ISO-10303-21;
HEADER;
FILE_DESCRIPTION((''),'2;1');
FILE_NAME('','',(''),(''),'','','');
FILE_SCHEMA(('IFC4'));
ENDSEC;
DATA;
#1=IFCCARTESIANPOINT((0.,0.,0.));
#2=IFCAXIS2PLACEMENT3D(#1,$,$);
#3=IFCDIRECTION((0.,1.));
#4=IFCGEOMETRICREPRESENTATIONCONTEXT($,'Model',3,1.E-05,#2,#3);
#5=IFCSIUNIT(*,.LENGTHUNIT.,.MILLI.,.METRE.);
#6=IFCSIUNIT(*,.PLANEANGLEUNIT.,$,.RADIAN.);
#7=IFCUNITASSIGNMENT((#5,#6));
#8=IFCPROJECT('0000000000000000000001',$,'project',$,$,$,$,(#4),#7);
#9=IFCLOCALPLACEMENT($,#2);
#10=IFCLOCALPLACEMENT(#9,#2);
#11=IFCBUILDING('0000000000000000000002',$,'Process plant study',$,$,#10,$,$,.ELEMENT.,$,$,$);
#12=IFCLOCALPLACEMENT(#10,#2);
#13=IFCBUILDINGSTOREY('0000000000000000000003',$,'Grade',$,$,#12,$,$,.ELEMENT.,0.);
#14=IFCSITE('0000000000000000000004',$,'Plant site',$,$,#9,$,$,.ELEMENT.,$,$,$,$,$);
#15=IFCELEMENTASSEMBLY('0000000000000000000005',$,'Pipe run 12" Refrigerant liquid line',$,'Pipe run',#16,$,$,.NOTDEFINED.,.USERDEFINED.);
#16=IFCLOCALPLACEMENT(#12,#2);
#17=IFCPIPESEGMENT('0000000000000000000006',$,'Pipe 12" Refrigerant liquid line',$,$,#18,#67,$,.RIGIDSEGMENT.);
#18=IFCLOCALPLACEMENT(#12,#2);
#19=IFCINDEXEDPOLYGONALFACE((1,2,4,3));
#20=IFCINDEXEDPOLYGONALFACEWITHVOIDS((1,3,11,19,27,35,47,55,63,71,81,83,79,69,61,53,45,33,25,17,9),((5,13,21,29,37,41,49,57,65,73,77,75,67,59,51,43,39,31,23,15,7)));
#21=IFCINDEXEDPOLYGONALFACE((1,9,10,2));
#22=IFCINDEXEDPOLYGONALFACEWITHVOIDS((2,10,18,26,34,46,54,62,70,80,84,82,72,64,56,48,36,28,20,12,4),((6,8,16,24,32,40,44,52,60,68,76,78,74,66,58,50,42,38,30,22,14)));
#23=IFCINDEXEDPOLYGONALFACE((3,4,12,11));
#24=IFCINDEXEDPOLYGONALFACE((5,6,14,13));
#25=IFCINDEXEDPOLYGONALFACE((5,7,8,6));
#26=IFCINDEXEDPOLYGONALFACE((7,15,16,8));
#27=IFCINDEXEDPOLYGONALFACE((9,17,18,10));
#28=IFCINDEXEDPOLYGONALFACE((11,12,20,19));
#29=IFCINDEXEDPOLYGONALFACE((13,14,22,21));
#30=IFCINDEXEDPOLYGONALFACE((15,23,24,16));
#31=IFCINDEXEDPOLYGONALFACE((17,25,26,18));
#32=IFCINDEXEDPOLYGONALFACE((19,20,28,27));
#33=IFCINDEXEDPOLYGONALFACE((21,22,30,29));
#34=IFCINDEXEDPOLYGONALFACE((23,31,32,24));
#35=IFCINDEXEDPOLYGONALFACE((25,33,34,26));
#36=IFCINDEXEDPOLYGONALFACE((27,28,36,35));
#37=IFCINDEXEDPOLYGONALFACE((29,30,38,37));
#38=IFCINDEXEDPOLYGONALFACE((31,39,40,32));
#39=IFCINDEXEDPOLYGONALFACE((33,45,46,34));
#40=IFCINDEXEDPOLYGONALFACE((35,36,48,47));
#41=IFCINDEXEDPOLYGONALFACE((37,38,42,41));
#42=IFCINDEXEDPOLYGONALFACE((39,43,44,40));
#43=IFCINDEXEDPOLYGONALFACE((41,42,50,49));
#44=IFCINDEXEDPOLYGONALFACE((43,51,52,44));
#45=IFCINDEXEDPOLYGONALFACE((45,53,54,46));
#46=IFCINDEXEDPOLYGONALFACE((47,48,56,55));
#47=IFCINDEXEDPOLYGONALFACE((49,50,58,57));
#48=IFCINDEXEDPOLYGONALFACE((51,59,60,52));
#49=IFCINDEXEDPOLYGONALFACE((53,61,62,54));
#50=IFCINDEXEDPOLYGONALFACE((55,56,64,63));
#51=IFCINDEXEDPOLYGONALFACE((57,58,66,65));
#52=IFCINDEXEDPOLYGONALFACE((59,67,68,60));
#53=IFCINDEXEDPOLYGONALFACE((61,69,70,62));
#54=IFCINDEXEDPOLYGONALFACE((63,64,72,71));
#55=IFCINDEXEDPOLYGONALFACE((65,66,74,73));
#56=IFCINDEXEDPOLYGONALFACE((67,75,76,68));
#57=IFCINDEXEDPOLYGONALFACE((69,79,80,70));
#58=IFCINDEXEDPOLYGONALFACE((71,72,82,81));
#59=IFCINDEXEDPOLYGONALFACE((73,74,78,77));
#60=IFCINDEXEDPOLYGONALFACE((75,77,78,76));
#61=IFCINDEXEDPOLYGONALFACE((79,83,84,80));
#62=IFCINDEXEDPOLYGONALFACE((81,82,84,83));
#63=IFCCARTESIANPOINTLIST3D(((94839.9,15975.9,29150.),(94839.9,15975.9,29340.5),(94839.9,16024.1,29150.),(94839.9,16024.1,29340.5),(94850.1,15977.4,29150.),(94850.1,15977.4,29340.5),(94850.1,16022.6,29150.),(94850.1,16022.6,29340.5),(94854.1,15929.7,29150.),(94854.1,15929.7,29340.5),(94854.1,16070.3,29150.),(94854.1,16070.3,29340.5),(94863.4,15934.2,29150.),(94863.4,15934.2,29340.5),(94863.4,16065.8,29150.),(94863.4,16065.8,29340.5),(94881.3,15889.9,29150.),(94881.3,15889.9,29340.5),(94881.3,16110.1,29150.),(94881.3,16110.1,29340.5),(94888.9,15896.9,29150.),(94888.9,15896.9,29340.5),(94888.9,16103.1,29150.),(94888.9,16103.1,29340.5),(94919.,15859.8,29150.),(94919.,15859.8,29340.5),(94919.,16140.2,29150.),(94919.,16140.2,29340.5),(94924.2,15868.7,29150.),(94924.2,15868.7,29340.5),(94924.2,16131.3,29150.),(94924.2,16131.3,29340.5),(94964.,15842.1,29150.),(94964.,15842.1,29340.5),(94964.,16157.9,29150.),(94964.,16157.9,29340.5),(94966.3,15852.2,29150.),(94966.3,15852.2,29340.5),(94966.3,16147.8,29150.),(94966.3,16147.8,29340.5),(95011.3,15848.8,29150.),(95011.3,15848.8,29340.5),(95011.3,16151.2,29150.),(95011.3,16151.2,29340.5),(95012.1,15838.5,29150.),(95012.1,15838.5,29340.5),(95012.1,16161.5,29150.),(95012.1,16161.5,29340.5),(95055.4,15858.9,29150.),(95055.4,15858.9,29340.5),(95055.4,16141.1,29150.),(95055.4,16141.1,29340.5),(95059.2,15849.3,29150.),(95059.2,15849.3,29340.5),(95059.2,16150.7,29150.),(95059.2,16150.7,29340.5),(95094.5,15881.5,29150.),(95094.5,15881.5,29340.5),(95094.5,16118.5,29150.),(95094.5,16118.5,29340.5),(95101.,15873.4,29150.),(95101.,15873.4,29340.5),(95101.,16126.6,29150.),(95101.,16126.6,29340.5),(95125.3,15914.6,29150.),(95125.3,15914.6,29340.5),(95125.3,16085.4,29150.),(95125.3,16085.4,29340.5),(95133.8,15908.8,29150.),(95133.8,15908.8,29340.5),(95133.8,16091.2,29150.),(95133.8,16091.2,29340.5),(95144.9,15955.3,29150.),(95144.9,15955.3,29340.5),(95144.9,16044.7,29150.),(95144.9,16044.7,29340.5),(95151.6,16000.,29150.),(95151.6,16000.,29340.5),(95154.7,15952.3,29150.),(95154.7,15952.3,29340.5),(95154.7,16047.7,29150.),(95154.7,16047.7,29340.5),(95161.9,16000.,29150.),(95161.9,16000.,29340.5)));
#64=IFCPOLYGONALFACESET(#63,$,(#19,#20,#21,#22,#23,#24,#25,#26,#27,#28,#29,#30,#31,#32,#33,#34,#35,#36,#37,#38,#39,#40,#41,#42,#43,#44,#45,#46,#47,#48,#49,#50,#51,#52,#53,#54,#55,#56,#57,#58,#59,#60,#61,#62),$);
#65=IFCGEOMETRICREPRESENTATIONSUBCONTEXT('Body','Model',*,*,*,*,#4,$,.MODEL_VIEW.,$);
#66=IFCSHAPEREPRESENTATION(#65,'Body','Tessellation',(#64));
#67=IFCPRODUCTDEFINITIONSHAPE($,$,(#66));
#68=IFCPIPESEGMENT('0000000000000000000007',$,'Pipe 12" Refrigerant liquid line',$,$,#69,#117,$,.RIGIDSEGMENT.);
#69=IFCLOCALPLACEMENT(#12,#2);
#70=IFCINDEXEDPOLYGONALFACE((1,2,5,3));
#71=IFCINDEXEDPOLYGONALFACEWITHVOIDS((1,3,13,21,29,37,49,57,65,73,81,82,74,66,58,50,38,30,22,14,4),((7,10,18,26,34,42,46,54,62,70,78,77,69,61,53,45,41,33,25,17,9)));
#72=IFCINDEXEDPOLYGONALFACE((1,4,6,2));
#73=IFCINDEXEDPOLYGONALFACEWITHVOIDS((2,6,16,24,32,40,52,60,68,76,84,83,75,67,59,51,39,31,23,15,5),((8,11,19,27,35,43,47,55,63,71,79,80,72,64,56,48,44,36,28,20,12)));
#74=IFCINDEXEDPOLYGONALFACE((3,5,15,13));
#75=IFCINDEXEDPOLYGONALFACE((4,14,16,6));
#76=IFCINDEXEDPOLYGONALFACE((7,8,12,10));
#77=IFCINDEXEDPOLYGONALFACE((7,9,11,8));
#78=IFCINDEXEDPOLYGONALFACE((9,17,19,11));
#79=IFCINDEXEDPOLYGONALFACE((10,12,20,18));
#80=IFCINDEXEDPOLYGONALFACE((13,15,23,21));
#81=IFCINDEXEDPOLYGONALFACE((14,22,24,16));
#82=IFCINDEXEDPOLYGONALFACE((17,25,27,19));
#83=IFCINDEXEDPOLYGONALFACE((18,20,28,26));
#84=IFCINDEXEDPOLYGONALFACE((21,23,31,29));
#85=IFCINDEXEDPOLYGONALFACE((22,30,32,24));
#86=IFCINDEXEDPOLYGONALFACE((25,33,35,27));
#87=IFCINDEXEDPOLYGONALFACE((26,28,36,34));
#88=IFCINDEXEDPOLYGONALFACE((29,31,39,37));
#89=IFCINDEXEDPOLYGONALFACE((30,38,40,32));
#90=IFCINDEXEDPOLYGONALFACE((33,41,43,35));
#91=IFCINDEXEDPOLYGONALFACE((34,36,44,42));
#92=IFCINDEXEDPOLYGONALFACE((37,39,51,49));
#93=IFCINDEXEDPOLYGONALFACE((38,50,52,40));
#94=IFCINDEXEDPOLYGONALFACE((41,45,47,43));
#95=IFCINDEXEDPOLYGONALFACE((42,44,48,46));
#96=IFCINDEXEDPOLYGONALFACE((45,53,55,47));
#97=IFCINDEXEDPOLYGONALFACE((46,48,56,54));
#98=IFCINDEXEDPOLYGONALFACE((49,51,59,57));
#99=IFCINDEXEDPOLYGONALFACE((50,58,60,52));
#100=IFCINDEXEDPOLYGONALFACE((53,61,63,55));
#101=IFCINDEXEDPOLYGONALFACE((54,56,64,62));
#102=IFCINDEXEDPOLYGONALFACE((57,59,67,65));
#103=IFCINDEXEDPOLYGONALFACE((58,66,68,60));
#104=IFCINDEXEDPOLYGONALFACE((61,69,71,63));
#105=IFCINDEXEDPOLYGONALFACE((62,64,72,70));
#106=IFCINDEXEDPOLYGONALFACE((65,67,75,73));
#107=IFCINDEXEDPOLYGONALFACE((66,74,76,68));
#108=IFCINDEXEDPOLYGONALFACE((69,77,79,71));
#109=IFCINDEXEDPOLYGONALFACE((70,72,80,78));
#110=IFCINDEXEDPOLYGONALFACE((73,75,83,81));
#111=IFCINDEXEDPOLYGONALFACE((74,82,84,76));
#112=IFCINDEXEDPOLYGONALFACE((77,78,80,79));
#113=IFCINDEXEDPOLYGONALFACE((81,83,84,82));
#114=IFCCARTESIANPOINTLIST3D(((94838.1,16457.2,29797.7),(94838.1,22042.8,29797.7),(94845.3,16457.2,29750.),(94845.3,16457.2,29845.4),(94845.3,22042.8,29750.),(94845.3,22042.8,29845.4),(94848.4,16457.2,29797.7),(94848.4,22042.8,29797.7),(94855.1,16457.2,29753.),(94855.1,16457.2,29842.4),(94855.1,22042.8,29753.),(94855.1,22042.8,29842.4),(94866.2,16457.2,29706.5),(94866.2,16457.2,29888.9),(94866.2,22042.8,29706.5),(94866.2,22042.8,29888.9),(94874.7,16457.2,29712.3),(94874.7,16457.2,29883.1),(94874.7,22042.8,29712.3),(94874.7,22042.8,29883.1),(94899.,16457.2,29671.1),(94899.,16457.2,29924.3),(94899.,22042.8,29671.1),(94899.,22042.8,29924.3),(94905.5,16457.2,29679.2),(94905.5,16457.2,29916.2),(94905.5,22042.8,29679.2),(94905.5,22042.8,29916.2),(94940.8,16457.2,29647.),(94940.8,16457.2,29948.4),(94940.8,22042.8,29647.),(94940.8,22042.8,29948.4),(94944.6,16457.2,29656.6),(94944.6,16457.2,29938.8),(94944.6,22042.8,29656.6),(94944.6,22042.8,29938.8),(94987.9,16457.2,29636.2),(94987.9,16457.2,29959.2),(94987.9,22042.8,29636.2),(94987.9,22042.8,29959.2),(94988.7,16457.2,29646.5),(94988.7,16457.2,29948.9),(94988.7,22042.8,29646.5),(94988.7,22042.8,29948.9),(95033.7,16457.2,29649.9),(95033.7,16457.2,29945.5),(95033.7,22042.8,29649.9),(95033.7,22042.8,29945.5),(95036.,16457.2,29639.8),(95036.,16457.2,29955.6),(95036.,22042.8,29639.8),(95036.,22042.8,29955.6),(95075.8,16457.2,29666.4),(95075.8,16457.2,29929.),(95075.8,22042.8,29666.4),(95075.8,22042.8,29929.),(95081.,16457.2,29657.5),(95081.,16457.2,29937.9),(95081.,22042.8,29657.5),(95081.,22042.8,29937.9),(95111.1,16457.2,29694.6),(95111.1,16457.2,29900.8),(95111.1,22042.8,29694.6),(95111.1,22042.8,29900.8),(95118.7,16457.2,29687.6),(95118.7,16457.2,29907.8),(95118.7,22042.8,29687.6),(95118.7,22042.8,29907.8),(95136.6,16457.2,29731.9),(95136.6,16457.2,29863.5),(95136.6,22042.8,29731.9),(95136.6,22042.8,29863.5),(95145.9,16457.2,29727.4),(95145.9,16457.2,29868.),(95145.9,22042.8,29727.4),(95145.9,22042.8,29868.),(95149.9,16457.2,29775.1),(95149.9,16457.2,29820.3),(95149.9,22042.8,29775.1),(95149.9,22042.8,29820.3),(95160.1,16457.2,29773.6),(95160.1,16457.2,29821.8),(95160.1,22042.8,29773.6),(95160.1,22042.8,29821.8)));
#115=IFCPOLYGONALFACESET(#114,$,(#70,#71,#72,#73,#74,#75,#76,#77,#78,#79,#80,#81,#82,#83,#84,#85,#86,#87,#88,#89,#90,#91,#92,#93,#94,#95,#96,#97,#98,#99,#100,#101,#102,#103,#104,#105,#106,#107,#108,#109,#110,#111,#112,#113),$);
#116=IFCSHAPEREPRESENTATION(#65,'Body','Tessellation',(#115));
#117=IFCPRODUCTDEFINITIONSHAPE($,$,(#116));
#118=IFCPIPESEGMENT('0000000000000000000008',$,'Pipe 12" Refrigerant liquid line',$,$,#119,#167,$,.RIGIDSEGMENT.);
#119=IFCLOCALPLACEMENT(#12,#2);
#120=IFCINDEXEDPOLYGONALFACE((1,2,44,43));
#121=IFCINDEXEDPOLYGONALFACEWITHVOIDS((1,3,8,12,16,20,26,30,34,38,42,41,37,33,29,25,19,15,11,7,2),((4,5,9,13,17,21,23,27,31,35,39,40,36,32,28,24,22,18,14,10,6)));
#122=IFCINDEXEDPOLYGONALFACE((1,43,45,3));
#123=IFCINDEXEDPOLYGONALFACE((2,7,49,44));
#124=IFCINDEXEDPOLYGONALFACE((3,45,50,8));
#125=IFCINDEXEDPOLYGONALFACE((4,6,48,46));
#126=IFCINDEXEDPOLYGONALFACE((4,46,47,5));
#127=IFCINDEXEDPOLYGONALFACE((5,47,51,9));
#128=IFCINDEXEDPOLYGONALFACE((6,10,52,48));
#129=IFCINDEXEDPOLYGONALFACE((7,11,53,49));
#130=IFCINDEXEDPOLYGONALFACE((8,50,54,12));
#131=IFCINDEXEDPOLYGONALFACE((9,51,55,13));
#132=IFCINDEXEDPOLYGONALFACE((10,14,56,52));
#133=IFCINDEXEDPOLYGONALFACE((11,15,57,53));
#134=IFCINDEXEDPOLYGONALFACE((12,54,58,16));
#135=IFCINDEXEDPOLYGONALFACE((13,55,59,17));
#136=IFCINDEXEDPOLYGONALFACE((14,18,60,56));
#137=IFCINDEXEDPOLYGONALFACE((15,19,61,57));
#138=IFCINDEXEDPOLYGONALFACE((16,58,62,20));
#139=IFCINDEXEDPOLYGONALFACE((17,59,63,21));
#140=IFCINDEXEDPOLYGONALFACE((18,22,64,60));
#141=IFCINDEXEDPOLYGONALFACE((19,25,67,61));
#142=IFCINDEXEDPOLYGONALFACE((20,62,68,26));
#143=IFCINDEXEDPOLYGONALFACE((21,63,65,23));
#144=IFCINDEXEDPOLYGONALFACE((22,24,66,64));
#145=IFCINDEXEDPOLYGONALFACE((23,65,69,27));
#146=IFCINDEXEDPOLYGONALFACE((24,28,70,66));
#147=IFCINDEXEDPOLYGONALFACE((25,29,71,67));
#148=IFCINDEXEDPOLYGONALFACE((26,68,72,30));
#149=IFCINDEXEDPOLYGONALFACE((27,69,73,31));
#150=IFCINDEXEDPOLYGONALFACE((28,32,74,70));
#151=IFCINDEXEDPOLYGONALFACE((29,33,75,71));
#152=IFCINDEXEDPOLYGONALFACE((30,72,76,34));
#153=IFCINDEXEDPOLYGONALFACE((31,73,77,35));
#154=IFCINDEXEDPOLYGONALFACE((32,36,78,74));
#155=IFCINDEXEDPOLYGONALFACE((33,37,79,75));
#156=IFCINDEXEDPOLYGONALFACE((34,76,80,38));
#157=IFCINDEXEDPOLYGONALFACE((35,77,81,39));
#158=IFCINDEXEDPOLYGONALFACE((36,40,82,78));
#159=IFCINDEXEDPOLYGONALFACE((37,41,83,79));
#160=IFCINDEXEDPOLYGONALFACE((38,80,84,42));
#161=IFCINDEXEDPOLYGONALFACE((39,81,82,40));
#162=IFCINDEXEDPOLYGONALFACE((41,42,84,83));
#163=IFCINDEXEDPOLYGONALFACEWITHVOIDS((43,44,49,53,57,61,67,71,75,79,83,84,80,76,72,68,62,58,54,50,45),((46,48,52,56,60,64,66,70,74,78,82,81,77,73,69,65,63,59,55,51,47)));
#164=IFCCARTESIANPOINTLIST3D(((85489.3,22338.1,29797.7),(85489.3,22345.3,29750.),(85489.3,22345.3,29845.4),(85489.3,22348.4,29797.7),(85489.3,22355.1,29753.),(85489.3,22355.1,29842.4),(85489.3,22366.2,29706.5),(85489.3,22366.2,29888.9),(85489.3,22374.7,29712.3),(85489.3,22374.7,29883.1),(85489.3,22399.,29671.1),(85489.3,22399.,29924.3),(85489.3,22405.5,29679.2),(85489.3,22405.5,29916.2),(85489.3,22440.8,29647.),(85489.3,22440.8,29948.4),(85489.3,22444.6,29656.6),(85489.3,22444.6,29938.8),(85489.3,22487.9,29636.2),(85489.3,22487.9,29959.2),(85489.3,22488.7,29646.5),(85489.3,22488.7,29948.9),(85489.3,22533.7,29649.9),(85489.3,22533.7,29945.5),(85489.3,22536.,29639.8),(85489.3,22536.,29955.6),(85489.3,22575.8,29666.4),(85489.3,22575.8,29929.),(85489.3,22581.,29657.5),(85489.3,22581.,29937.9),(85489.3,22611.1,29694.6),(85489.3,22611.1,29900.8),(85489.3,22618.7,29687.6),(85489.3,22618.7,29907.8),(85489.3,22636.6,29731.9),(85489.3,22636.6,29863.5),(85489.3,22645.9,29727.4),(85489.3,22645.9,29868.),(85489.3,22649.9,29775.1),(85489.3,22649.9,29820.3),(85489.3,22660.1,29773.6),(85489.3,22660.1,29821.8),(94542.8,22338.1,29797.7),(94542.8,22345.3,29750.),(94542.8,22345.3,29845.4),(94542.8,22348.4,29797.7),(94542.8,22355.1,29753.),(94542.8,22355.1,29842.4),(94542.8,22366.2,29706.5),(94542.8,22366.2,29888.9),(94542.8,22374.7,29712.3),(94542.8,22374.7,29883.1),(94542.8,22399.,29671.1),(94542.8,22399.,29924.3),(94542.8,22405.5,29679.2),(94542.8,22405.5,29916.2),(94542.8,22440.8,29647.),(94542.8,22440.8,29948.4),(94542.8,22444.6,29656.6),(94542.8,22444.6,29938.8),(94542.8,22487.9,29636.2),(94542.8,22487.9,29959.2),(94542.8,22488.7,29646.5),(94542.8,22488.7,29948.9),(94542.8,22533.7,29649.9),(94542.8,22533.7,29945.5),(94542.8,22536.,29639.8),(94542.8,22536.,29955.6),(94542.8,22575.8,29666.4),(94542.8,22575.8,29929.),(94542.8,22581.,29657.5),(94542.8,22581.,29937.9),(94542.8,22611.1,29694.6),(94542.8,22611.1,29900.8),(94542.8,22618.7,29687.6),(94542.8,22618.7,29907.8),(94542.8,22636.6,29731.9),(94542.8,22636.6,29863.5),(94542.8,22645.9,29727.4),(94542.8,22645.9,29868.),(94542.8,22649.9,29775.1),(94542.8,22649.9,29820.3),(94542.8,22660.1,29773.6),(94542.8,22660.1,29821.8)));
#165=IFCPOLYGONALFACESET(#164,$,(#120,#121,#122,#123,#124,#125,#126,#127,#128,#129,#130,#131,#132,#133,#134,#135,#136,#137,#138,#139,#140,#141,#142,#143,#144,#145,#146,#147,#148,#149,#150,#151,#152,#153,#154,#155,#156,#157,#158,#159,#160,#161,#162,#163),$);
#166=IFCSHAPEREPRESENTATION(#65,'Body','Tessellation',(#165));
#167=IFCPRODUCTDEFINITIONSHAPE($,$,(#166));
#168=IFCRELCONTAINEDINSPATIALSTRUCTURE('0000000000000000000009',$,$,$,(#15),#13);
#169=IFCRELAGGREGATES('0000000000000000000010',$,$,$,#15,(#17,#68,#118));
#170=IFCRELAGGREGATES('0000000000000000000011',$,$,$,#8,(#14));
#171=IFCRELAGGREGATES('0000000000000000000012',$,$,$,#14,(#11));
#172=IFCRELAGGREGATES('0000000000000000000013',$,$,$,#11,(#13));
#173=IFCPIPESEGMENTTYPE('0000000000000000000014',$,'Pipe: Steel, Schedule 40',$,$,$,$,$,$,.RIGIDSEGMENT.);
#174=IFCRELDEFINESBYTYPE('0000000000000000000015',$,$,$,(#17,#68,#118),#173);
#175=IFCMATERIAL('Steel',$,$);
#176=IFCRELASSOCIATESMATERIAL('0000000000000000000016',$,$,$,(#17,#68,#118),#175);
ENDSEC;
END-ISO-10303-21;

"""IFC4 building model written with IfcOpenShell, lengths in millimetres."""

from ifc_helpers import new_model, si_unit, direction, frame, origin, origin_with_axes, origin_2d, place, context, subcontext, project, spatial, hollow_circle, extrude, material, type_object, element, aggregate, save


model = new_model("IFC4")

# Units and contexts
model_context = context("Model", 3, precision=1e-05, world=origin(), true_north=direction((0.0, 1.0)))
body_context = subcontext(model_context, "Body", "Model", "MODEL_VIEW")
ifc_project = project(units=[si_unit("LENGTHUNIT", "METRE", prefix="MILLI"), si_unit("PLANEANGLEUNIT", "RADIAN")], contexts=[model_context])

# Site, building, storey
site_placement = place(None, origin())
site = spatial("IfcSite", under=ifc_project, at=site_placement, Name="Plant site", CompositionType="ELEMENT")
building_placement = place(site_placement, origin())
building = spatial("IfcBuilding", under=site, at=building_placement, Name="Process plant study", CompositionType="ELEMENT")
storey_placement = place(building_placement, origin())
storey = spatial("IfcBuildingStorey", under=building, at=storey_placement, Name="Grade", CompositionType="ELEMENT", Elevation=0.0)

# Element assembly, pipe segments
ifc_material = material(Name="Steel")
pipe_segment_type = type_object("IfcPipeSegmentType", Name="Pipe: Steel, Schedule 40", PredefinedType="RIGIDSEGMENT")
assembly_1_placement = place(storey_placement, origin_with_axes())
assembly_1 = element("IfcElementAssembly", 1, at=assembly_1_placement, inside=storey, Name="Pipe run 12\" Refrigerant liquid line", ObjectType="Pipe run", AssemblyPlace="NOTDEFINED", PredefinedType="USERDEFINED")
pipe_segment_1_placement = place(storey_placement, origin_with_axes())
pipe_segment_1 = element("IfcPipeSegment", 2, at=pipe_segment_1_placement, type_object=pipe_segment_type, material=ifc_material, Name="Pipe 12\" Refrigerant liquid line", PredefinedType="RIGIDSEGMENT", context=body_context, shape_type="SweptSolid", body=[
    extrude(hollow_circle(Radius=161.9, WallThickness=10.3, at=origin_2d()), frame((95000.0, 16000.0, 29150.0), z_axis=(0.0, 0.0, 1.0), x_axis=(1.0, 0.0, 0.0)), (0.0, 0.0, 1.0), 190.5),
])
pipe_segment_2_placement = place(storey_placement, origin_with_axes())
pipe_segment_2 = element("IfcPipeSegment", 3, at=pipe_segment_2_placement, type_object=pipe_segment_type, material=ifc_material, Name="Pipe 12\" Refrigerant liquid line", PredefinedType="RIGIDSEGMENT", context=body_context, shape_type="SweptSolid", body=[
    extrude(hollow_circle(Radius=161.9, WallThickness=10.3, at=origin_2d()), frame((95000.0, 16457.2, 29797.7), z_axis=(0.0, 1.0, 0.0), x_axis=(-1.0, 0.0, 0.0)), (0.0, 0.0, 1.0), 5585.6),
])
pipe_segment_3_placement = place(storey_placement, origin_with_axes())
pipe_segment_3 = element("IfcPipeSegment", 4, at=pipe_segment_3_placement, type_object=pipe_segment_type, material=ifc_material, Name="Pipe 12\" Refrigerant liquid line", PredefinedType="RIGIDSEGMENT", context=body_context, shape_type="SweptSolid", body=[
    extrude(hollow_circle(Radius=161.9, WallThickness=10.3, at=origin_2d()), frame((94542.8, 22500.0, 29797.7), z_axis=(-1.0, 0.0, 0.0), x_axis=(0.0, -1.0, 0.0)), (0.0, 0.0, 1.0), 9053.5),
])

aggregate(assembly_1, [pipe_segment_1, pipe_segment_2, pipe_segment_3])

save(model, "model.ifc")
